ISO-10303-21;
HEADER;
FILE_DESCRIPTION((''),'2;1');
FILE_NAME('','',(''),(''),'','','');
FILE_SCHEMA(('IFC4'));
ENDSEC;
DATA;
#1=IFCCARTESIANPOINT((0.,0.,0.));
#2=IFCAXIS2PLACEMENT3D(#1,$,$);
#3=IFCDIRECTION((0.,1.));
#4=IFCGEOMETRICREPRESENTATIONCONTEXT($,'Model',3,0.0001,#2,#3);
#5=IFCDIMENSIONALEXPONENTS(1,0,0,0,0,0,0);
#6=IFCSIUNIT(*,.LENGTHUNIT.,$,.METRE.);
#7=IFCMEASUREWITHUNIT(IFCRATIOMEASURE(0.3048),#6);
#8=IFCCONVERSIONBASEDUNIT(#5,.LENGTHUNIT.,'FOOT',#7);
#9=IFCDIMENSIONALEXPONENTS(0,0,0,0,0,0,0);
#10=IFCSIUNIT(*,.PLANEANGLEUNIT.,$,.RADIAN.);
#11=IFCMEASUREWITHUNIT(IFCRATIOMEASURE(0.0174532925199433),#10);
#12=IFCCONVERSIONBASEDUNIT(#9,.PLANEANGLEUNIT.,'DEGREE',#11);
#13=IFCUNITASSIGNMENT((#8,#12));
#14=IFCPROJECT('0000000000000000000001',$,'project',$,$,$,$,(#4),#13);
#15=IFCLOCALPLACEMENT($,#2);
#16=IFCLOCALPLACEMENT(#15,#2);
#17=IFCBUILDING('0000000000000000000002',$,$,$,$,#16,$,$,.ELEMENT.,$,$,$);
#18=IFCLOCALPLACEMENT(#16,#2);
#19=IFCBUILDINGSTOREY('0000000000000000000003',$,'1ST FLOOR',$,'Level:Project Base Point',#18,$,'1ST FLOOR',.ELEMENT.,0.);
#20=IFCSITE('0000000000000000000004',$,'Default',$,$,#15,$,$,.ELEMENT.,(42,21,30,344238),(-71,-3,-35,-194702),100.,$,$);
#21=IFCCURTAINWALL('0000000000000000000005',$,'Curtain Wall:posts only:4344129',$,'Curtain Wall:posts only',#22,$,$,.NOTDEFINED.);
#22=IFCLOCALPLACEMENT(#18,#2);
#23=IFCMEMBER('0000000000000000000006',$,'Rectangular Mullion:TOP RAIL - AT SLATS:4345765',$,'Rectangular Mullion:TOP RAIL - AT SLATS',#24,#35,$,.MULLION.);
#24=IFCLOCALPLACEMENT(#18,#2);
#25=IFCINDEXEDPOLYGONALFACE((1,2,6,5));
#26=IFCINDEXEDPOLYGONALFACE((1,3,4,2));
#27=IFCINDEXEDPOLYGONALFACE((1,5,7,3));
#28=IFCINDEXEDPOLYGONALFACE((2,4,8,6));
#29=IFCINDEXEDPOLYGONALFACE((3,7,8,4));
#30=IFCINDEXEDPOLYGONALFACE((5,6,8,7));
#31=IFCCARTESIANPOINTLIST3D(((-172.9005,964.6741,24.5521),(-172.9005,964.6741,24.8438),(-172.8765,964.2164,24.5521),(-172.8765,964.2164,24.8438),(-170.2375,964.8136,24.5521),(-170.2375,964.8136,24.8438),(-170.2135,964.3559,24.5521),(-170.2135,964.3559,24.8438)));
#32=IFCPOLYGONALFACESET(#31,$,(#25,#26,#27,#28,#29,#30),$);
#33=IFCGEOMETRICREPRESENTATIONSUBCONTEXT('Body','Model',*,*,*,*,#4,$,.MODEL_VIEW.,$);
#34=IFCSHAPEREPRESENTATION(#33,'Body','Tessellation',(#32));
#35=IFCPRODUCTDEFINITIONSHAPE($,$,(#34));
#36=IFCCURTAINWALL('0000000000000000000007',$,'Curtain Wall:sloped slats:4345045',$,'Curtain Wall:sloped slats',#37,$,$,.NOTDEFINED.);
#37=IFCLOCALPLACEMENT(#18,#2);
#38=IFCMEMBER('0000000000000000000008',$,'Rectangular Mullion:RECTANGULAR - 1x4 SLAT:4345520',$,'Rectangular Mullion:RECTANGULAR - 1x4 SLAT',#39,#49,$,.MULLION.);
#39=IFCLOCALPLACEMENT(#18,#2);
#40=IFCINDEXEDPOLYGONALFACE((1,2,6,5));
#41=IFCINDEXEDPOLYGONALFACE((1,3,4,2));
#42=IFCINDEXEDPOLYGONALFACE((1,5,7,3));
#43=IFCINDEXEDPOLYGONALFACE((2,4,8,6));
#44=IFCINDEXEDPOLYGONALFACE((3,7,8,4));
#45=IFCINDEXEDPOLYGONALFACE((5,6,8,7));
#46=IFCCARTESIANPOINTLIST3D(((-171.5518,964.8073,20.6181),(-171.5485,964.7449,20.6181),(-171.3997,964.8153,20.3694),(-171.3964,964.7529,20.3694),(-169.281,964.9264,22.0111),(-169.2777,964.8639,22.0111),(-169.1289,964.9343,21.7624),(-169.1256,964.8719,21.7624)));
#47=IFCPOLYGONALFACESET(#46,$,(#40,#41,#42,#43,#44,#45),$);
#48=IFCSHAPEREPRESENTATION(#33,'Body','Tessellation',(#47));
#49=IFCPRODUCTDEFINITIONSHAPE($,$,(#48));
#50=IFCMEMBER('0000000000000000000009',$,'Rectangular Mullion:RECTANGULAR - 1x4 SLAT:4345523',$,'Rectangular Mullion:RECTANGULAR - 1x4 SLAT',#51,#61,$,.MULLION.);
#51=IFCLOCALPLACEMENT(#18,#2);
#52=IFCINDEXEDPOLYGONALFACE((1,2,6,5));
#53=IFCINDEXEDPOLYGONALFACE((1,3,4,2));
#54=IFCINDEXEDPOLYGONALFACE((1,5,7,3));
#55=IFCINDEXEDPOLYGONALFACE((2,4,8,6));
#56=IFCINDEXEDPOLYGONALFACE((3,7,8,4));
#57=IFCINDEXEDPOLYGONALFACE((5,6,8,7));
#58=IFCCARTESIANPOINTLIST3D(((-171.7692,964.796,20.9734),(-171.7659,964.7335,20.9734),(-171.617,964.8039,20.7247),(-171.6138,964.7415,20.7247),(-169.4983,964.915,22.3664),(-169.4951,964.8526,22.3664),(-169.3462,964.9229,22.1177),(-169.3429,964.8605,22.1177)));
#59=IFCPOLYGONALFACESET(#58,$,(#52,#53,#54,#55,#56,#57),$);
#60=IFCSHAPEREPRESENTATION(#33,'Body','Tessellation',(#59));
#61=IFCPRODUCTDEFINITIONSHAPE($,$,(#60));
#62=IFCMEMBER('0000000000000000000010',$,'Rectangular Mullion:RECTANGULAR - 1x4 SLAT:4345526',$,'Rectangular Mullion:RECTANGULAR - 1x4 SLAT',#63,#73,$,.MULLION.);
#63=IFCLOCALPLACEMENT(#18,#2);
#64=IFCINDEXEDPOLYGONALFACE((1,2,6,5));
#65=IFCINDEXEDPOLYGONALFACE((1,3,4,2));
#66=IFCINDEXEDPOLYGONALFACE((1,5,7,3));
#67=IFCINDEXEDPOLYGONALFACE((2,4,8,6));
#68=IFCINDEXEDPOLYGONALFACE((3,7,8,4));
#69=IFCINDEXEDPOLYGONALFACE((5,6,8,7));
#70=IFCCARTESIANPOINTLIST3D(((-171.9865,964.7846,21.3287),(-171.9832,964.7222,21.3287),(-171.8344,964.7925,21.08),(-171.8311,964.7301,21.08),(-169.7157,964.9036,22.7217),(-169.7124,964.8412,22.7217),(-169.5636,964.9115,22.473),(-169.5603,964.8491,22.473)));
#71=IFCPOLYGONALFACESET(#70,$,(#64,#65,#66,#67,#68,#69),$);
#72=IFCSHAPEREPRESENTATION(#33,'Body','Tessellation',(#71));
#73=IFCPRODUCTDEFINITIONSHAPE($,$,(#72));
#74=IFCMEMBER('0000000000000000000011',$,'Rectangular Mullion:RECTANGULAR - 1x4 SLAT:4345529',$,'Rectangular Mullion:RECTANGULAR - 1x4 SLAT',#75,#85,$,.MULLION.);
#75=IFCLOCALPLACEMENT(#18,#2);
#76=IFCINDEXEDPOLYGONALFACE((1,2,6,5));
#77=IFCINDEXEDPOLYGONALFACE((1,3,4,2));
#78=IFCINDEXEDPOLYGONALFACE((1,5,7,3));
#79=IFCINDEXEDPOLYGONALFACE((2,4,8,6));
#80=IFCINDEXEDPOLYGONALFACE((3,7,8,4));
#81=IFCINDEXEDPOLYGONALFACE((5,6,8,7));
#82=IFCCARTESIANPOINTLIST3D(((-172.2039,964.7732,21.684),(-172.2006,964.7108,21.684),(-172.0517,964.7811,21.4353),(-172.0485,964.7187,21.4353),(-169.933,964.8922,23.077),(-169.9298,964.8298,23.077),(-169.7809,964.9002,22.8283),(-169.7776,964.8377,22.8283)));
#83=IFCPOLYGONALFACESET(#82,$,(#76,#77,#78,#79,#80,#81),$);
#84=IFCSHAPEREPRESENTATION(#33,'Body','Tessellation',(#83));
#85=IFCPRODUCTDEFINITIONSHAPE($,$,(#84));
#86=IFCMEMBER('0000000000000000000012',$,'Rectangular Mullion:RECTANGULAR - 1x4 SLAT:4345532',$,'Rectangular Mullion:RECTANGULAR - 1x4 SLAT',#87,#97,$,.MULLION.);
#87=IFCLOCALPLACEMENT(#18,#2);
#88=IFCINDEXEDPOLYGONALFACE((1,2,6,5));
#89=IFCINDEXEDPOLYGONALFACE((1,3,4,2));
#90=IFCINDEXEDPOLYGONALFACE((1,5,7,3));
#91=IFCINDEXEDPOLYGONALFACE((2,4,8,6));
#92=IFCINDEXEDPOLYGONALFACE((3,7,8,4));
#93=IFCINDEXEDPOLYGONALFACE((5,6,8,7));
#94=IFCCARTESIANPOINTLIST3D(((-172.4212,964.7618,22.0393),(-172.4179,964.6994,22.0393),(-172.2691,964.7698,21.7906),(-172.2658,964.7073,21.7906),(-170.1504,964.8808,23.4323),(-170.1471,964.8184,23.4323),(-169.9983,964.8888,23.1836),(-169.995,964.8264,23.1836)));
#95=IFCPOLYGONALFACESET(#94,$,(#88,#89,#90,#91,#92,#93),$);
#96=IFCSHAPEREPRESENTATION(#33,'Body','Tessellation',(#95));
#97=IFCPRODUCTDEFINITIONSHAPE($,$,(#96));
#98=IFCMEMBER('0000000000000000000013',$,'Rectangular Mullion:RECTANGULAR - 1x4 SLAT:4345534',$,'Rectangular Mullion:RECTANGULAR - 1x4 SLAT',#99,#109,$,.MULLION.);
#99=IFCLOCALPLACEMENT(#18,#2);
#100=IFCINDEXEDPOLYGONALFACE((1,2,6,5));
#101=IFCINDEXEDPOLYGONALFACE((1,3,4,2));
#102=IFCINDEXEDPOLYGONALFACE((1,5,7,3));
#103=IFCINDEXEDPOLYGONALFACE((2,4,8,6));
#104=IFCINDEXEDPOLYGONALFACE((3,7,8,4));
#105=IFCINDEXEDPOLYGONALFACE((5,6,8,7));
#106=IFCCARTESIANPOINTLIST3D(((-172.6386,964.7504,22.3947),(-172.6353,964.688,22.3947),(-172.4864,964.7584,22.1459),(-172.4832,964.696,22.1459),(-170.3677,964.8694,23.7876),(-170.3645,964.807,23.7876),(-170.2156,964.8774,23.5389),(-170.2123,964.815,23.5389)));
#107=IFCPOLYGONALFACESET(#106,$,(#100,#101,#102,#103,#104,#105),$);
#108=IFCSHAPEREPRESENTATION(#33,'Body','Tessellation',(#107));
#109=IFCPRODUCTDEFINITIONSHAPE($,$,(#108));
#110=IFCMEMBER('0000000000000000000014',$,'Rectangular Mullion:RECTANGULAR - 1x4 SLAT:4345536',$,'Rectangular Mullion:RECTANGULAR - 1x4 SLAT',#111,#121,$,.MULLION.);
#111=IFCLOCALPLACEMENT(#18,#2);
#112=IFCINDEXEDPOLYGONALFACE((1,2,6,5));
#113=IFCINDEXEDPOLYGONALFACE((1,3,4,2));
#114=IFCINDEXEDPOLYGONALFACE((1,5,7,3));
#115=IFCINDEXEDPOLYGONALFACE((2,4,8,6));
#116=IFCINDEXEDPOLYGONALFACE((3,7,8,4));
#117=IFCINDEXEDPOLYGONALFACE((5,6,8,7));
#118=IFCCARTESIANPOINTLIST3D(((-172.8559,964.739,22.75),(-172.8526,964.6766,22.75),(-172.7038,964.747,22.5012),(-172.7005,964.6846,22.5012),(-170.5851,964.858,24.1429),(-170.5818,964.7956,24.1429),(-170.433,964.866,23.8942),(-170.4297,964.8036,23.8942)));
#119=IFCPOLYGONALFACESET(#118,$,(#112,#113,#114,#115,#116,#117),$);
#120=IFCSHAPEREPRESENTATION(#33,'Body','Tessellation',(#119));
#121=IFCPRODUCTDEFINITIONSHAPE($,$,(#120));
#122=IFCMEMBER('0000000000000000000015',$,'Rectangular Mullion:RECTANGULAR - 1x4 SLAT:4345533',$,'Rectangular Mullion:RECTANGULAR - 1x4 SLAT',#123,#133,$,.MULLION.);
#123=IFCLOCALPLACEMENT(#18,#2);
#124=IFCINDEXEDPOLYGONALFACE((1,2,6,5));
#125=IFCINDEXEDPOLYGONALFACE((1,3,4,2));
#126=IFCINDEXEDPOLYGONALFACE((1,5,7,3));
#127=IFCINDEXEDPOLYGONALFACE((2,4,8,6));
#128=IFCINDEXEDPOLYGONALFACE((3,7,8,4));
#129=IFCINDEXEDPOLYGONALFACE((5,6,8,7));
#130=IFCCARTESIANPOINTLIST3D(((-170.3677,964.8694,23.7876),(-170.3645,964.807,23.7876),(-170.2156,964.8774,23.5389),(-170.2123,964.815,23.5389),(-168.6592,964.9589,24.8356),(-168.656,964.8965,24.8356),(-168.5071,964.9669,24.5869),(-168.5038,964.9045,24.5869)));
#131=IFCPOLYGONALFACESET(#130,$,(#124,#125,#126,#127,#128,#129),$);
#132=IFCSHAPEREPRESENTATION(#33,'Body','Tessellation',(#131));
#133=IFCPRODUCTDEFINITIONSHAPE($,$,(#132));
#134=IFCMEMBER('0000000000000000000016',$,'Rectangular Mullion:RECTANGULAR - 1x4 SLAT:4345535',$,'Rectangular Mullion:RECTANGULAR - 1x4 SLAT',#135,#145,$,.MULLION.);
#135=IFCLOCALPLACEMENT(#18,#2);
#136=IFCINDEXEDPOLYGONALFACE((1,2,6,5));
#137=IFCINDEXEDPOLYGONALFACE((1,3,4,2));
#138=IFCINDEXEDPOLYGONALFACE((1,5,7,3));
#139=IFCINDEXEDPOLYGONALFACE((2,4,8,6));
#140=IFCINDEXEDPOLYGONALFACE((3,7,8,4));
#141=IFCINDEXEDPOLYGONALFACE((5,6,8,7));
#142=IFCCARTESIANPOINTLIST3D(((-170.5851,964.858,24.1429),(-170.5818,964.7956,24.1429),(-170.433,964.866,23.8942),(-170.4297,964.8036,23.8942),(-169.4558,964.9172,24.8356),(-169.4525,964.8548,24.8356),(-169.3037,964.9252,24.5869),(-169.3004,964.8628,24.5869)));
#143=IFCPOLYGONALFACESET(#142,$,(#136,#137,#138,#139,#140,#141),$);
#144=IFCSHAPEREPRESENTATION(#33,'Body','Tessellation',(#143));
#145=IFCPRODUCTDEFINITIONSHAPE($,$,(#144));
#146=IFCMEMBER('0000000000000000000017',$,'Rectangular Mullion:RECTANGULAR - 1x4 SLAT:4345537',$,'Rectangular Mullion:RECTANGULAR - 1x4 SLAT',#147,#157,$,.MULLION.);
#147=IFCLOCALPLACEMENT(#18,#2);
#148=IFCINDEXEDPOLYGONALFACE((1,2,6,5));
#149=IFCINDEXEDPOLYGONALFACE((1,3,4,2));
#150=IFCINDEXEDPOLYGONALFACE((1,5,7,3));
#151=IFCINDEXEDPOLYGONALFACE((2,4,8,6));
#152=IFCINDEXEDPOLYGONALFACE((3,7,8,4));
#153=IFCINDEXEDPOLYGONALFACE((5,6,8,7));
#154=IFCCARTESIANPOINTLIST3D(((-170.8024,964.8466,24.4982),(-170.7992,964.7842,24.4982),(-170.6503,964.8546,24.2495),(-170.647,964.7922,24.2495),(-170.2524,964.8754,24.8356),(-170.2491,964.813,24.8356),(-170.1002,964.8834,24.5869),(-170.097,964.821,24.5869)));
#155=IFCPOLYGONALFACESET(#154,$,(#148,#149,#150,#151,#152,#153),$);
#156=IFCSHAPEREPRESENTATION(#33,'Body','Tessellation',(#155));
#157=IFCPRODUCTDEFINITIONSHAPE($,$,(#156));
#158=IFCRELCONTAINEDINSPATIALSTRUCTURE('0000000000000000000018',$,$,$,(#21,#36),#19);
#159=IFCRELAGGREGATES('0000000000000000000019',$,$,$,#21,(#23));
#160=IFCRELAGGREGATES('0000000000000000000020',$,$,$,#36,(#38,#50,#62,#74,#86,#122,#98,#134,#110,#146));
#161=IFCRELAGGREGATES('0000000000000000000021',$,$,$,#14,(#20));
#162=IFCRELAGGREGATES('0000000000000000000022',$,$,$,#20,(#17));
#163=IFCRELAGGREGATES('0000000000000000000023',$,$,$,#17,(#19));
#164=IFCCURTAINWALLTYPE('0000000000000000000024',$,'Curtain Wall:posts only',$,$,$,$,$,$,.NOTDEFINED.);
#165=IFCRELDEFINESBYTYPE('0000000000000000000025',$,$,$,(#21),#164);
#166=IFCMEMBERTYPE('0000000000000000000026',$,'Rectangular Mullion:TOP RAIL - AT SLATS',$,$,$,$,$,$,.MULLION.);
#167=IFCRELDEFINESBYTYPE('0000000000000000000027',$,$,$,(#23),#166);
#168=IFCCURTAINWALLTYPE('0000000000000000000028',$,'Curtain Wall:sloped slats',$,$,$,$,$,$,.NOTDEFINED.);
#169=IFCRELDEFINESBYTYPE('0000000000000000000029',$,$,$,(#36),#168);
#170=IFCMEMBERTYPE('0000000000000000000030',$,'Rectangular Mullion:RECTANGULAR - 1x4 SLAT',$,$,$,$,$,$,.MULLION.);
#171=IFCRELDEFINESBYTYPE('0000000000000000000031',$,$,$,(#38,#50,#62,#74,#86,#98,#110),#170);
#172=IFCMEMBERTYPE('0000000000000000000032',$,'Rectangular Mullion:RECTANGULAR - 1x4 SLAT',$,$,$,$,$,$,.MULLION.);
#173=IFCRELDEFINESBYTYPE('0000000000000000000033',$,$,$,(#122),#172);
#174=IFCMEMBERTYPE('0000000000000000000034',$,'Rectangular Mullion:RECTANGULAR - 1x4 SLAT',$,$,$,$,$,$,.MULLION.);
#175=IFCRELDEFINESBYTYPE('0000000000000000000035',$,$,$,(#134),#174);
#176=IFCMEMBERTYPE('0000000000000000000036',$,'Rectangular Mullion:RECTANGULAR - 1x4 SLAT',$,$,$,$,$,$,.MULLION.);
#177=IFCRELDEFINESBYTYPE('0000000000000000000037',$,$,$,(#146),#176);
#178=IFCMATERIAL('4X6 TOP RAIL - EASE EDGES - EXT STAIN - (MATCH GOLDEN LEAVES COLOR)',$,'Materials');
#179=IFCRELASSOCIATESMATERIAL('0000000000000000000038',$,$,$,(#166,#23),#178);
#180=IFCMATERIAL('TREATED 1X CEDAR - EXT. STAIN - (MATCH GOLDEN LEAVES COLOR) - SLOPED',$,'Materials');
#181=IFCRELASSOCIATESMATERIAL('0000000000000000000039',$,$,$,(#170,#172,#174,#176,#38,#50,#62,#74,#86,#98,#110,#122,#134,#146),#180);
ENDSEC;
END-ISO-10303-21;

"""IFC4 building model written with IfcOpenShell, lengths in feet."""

from ifc_helpers import new_model, entity, si_unit, converted_unit, direction, frame, frame_2d, origin, origin_2d_with_axis, place, context, subcontext, project, spatial, rectangle, extrude, source, transform, mapped, material, material_profile, profile_set, profile_usage, type_object, type_shapes, element, aggregate, save


model = new_model("IFC4")

# Units and contexts
model_context = context("Model", 3, precision=0.0001, world=origin(), true_north=direction((0.0, 1.0)))
body_context = subcontext(model_context, "Body", "Model", "MODEL_VIEW")
ifc_project = project(units=[converted_unit("LENGTHUNIT", "FOOT", entity("IfcRatioMeasure", 0.3048), si_unit("LENGTHUNIT", "METRE"), dimensions=[1, 0, 0, 0, 0, 0, 0]), converted_unit("PLANEANGLEUNIT", "DEGREE", entity("IfcRatioMeasure", 0.0174532925199433), si_unit("PLANEANGLEUNIT", "RADIAN"), dimensions=[0, 0, 0, 0, 0, 0, 0])], contexts=[model_context])

# Site, building, storey
site_placement = place(None, origin())
site = spatial("IfcSite", under=ifc_project, at=site_placement, Name="Default", CompositionType="ELEMENT", RefLatitude=(42, 21, 30, 344238), RefLongitude=(-71, -3, -35, -194702), RefElevation=100.0)
building_placement = place(site_placement, origin())
building = spatial("IfcBuilding", under=site, at=building_placement, CompositionType="ELEMENT")
storey_placement = place(building_placement, origin())
storey = spatial("IfcBuildingStorey", under=building, at=storey_placement, Name="1ST FLOOR", ObjectType="Level:Project Base Point", LongName="1ST FLOOR", CompositionType="ELEMENT", Elevation=0.0)

# Curtain walls, members
curtain_wall_type_1 = type_object("IfcCurtainWallType", Name="Curtain Wall:posts only", PredefinedType="NOTDEFINED")
curtain_wall_1_placement = place(storey_placement, origin())
curtain_wall_1 = element("IfcCurtainWall", 1, at=curtain_wall_1_placement, inside=storey, type_object=curtain_wall_type_1, Name="Curtain Wall:posts only:4344129", ObjectType="Curtain Wall:posts only", PredefinedType="NOTDEFINED")
ifc_material_1 = material(Name="4X6 TOP RAIL - EASE EDGES - EXT STAIN - (MATCH GOLDEN LEAVES COLOR)", Category="Materials")
ifc_material_profile_1 = material_profile(ifc_material_1, rectangle(XDim=0.4583, YDim=0.2917, at=origin_2d_with_axis()), Name="TOP RAIL - AT SLATS")
ifc_profile_set_1 = profile_set([ifc_material_profile_1], Name="TOP RAIL - AT SLATS")
ifc_profile_usage_1 = profile_usage(ifc_profile_set_1)
member_type_1 = type_object("IfcMemberType", Name="Rectangular Mullion:TOP RAIL - AT SLATS", PredefinedType="MULLION", material=ifc_profile_set_1)
shared_shape_1 = source(origin(), body_context, "Body", "SweptSolid", [
    extrude(rectangle(XDim=0.4583, YDim=0.2917, at=origin_2d_with_axis()), frame((-0.1458, -0.2917, -2.6667), z_axis=(0.0, 0.0, 1.0), x_axis=(0.0, -1.0, 0.0)), (0.0, 0.0, 1.0), 2.6667),
])
type_shapes(member_type_1, [shared_shape_1])
member_1_placement = place(storey_placement, frame((-172.9038, 964.7365, 24.8438), z_axis=(-0.99863, -0.052336, 0.0), x_axis=(0.0, 0.0, 1.0)))
member_1 = element("IfcMember", 2, at=member_1_placement, type_object=member_type_1, material=ifc_profile_usage_1, Name="Rectangular Mullion:TOP RAIL - AT SLATS:4345765", ObjectType="Rectangular Mullion:TOP RAIL - AT SLATS", PredefinedType="MULLION", context=body_context, shape_type="MappedRepresentation", body=[
    mapped(shared_shape_1, transform((0.0, 0.0, 0.0), scale=1.0)),
])
aggregate(curtain_wall_1, [member_1])
curtain_wall_type_2 = type_object("IfcCurtainWallType", Name="Curtain Wall:sloped slats", PredefinedType="NOTDEFINED")
curtain_wall_2_placement = place(storey_placement, origin())
curtain_wall_2 = element("IfcCurtainWall", 3, at=curtain_wall_2_placement, inside=storey, type_object=curtain_wall_type_2, Name="Curtain Wall:sloped slats:4345045", ObjectType="Curtain Wall:sloped slats", PredefinedType="NOTDEFINED")
ifc_material_2 = material(Name="TREATED 1X CEDAR - EXT. STAIN - (MATCH GOLDEN LEAVES COLOR) - SLOPED", Category="Materials")
ifc_material_profile_2 = material_profile(ifc_material_2, rectangle(XDim=0.0625, YDim=0.2917, at=frame_2d((0.0, 0.0), x_axis=(1.0, 0.0))), Name="RECTANGULAR - 1x4 SLAT")
ifc_profile_set_2 = profile_set([ifc_material_profile_2], Name="RECTANGULAR - 1x4 SLAT")
ifc_profile_usage_2 = profile_usage(ifc_profile_set_2)
member_type_2 = type_object("IfcMemberType", Name="Rectangular Mullion:RECTANGULAR - 1x4 SLAT", PredefinedType="MULLION", material=ifc_profile_set_2)
shared_shape_2 = source(origin(), body_context, "Body", "SweptSolid", [
    extrude(rectangle(XDim=0.0625, YDim=0.2917, at=frame_2d((0.0, 0.0), x_axis=(1.0, 0.0))), frame((0.0, 0.0, -2.6667), z_axis=(0.0, 0.0, 1.0), x_axis=(0.0, -1.0, 0.0)), (0.0, 0.0, 1.0), 2.6667),
])
type_shapes(member_type_2, [shared_shape_2])
member_2_placement = place(storey_placement, frame((-171.4741, 964.7801, 20.4938), z_axis=(-0.851559, -0.044628, -0.522356), x_axis=(-0.52164, -0.027338, 0.852727)))
member_2 = element("IfcMember", 4, at=member_2_placement, type_object=member_type_2, material=ifc_profile_usage_2, Name="Rectangular Mullion:RECTANGULAR - 1x4 SLAT:4345520", ObjectType="Rectangular Mullion:RECTANGULAR - 1x4 SLAT", PredefinedType="MULLION", context=body_context, shape_type="MappedRepresentation", body=[
    mapped(shared_shape_2, transform((0.0, 0.0, 0.0), scale=1.0)),
])
ifc_profile_usage_3 = profile_usage(ifc_profile_set_2)
member_3_placement = place(storey_placement, frame((-171.6915, 964.7687, 20.8491), z_axis=(-0.851559, -0.044628, -0.522356), x_axis=(-0.52164, -0.027338, 0.852727)))
member_3 = element("IfcMember", 5, at=member_3_placement, type_object=member_type_2, material=ifc_profile_usage_3, Name="Rectangular Mullion:RECTANGULAR - 1x4 SLAT:4345523", ObjectType="Rectangular Mullion:RECTANGULAR - 1x4 SLAT", PredefinedType="MULLION", context=body_context, shape_type="MappedRepresentation", body=[
    mapped(shared_shape_2, transform((0.0, 0.0, 0.0), scale=1.0)),
])
ifc_profile_usage_4 = profile_usage(ifc_profile_set_2)
member_4_placement = place(storey_placement, frame((-171.9088, 964.7573, 21.2044), z_axis=(-0.851559, -0.044628, -0.522356), x_axis=(-0.52164, -0.027338, 0.852727)))
member_4 = element("IfcMember", 6, at=member_4_placement, type_object=member_type_2, material=ifc_profile_usage_4, Name="Rectangular Mullion:RECTANGULAR - 1x4 SLAT:4345526", ObjectType="Rectangular Mullion:RECTANGULAR - 1x4 SLAT", PredefinedType="MULLION", context=body_context, shape_type="MappedRepresentation", body=[
    mapped(shared_shape_2, transform((0.0, 0.0, 0.0), scale=1.0)),
])
ifc_profile_usage_5 = profile_usage(ifc_profile_set_2)
member_5_placement = place(storey_placement, frame((-172.1262, 964.746, 21.5597), z_axis=(-0.851559, -0.044628, -0.522356), x_axis=(-0.52164, -0.027338, 0.852727)))
member_5 = element("IfcMember", 7, at=member_5_placement, type_object=member_type_2, material=ifc_profile_usage_5, Name="Rectangular Mullion:RECTANGULAR - 1x4 SLAT:4345529", ObjectType="Rectangular Mullion:RECTANGULAR - 1x4 SLAT", PredefinedType="MULLION", context=body_context, shape_type="MappedRepresentation", body=[
    mapped(shared_shape_2, transform((0.0, 0.0, 0.0), scale=1.0)),
])
ifc_profile_usage_6 = profile_usage(ifc_profile_set_2)
member_6_placement = place(storey_placement, frame((-172.3435, 964.7346, 21.915), z_axis=(-0.851559, -0.044628, -0.522356), x_axis=(-0.52164, -0.027338, 0.852727)))
member_6 = element("IfcMember", 8, at=member_6_placement, type_object=member_type_2, material=ifc_profile_usage_6, Name="Rectangular Mullion:RECTANGULAR - 1x4 SLAT:4345532", ObjectType="Rectangular Mullion:RECTANGULAR - 1x4 SLAT", PredefinedType="MULLION", context=body_context, shape_type="MappedRepresentation", body=[
    mapped(shared_shape_2, transform((0.0, 0.0, 0.0), scale=1.0)),
])
ifc_profile_usage_7 = profile_usage(ifc_profile_set_2)
member_7_placement = place(storey_placement, frame((-172.5609, 964.7232, 22.2703), z_axis=(-0.851559, -0.044628, -0.522356), x_axis=(-0.52164, -0.027338, 0.852727)))
member_7 = element("IfcMember", 9, at=member_7_placement, type_object=member_type_2, material=ifc_profile_usage_7, Name="Rectangular Mullion:RECTANGULAR - 1x4 SLAT:4345534", ObjectType="Rectangular Mullion:RECTANGULAR - 1x4 SLAT", PredefinedType="MULLION", context=body_context, shape_type="MappedRepresentation", body=[
    mapped(shared_shape_2, transform((0.0, 0.0, 0.0), scale=1.0)),
])
ifc_profile_usage_8 = profile_usage(ifc_profile_set_2)
member_8_placement = place(storey_placement, frame((-172.7782, 964.7118, 22.6256), z_axis=(-0.851559, -0.044628, -0.522356), x_axis=(-0.52164, -0.027338, 0.852727)))
member_8 = element("IfcMember", 10, at=member_8_placement, type_object=member_type_2, material=ifc_profile_usage_8, Name="Rectangular Mullion:RECTANGULAR - 1x4 SLAT:4345536", ObjectType="Rectangular Mullion:RECTANGULAR - 1x4 SLAT", PredefinedType="MULLION", context=body_context, shape_type="MappedRepresentation", body=[
    mapped(shared_shape_2, transform((0.0, 0.0, 0.0), scale=1.0)),
])
ifc_profile_usage_9 = profile_usage(ifc_profile_set_2)
member_type_3 = type_object("IfcMemberType", Name="Rectangular Mullion:RECTANGULAR - 1x4 SLAT", PredefinedType="MULLION", material=ifc_profile_set_2)
shared_shape_3 = source(origin(), body_context, "Body", "SweptSolid", [
    extrude(rectangle(XDim=0.0625, YDim=0.2917, at=frame_2d((0.0, 0.0), x_axis=(1.0, 0.0))), frame((0.0, 0.0, -2.0063), z_axis=(0.0, 0.0, 1.0), x_axis=(0.0, -1.0, 0.0)), (0.0, 0.0, 1.0), 2.0063),
])
type_shapes(member_type_3, [shared_shape_3])
member_9_placement = place(storey_placement, frame((-170.29, 964.8422, 23.6632), z_axis=(-0.851559, -0.044628, -0.522356), x_axis=(-0.52164, -0.027338, 0.852727)))
member_9 = element("IfcMember", 11, at=member_9_placement, type_object=member_type_3, material=ifc_profile_usage_9, Name="Rectangular Mullion:RECTANGULAR - 1x4 SLAT:4345533", ObjectType="Rectangular Mullion:RECTANGULAR - 1x4 SLAT", PredefinedType="MULLION", context=body_context, shape_type="MappedRepresentation", body=[
    mapped(shared_shape_3, transform((0.0, 0.0, 0.0), scale=1.0)),
])
ifc_profile_usage_10 = profile_usage(ifc_profile_set_2)
member_type_4 = type_object("IfcMemberType", Name="Rectangular Mullion:RECTANGULAR - 1x4 SLAT", PredefinedType="MULLION", material=ifc_profile_set_2)
shared_shape_4 = source(origin(), body_context, "Body", "SweptSolid", [
    extrude(rectangle(XDim=0.0625, YDim=0.2917, at=origin_2d_with_axis()), frame((0.0, 0.0, -1.3261), z_axis=(0.0, 0.0, 1.0), x_axis=(0.0, -1.0, 0.0)), (0.0, 0.0, 1.0), 1.3261),
])
type_shapes(member_type_4, [shared_shape_4])
member_10_placement = place(storey_placement, frame((-170.5074, 964.8308, 24.0185), z_axis=(-0.851559, -0.044628, -0.522356), x_axis=(-0.52164, -0.027338, 0.852727)))
member_10 = element("IfcMember", 12, at=member_10_placement, type_object=member_type_4, material=ifc_profile_usage_10, Name="Rectangular Mullion:RECTANGULAR - 1x4 SLAT:4345535", ObjectType="Rectangular Mullion:RECTANGULAR - 1x4 SLAT", PredefinedType="MULLION", context=body_context, shape_type="MappedRepresentation", body=[
    mapped(shared_shape_4, transform((0.0, 0.0, 0.0), scale=1.0)),
])
ifc_profile_usage_11 = profile_usage(ifc_profile_set_2)
member_type_5 = type_object("IfcMemberType", Name="Rectangular Mullion:RECTANGULAR - 1x4 SLAT", PredefinedType="MULLION", material=ifc_profile_set_2)
shared_shape_5 = source(origin(), body_context, "Body", "SweptSolid", [
    extrude(rectangle(XDim=0.0625, YDim=0.2917, at=origin_2d_with_axis()), frame((0.0, 0.0, -0.6459), z_axis=(0.0, 0.0, 1.0), x_axis=(0.0, -1.0, 0.0)), (0.0, 0.0, 1.0), 0.6459),
])
type_shapes(member_type_5, [shared_shape_5])
member_11_placement = place(storey_placement, frame((-170.7247, 964.8194, 24.3739), z_axis=(-0.851559, -0.044628, -0.522356), x_axis=(-0.52164, -0.027338, 0.852727)))
member_11 = element("IfcMember", 13, at=member_11_placement, type_object=member_type_5, material=ifc_profile_usage_11, Name="Rectangular Mullion:RECTANGULAR - 1x4 SLAT:4345537", ObjectType="Rectangular Mullion:RECTANGULAR - 1x4 SLAT", PredefinedType="MULLION", context=body_context, shape_type="MappedRepresentation", body=[
    mapped(shared_shape_5, transform((0.0, 0.0, 0.0), scale=1.0)),
])
aggregate(curtain_wall_2, [member_2, member_3, member_4, member_5, member_6, member_9, member_7, member_10, member_8, member_11])

save(model, "model.ifc")
